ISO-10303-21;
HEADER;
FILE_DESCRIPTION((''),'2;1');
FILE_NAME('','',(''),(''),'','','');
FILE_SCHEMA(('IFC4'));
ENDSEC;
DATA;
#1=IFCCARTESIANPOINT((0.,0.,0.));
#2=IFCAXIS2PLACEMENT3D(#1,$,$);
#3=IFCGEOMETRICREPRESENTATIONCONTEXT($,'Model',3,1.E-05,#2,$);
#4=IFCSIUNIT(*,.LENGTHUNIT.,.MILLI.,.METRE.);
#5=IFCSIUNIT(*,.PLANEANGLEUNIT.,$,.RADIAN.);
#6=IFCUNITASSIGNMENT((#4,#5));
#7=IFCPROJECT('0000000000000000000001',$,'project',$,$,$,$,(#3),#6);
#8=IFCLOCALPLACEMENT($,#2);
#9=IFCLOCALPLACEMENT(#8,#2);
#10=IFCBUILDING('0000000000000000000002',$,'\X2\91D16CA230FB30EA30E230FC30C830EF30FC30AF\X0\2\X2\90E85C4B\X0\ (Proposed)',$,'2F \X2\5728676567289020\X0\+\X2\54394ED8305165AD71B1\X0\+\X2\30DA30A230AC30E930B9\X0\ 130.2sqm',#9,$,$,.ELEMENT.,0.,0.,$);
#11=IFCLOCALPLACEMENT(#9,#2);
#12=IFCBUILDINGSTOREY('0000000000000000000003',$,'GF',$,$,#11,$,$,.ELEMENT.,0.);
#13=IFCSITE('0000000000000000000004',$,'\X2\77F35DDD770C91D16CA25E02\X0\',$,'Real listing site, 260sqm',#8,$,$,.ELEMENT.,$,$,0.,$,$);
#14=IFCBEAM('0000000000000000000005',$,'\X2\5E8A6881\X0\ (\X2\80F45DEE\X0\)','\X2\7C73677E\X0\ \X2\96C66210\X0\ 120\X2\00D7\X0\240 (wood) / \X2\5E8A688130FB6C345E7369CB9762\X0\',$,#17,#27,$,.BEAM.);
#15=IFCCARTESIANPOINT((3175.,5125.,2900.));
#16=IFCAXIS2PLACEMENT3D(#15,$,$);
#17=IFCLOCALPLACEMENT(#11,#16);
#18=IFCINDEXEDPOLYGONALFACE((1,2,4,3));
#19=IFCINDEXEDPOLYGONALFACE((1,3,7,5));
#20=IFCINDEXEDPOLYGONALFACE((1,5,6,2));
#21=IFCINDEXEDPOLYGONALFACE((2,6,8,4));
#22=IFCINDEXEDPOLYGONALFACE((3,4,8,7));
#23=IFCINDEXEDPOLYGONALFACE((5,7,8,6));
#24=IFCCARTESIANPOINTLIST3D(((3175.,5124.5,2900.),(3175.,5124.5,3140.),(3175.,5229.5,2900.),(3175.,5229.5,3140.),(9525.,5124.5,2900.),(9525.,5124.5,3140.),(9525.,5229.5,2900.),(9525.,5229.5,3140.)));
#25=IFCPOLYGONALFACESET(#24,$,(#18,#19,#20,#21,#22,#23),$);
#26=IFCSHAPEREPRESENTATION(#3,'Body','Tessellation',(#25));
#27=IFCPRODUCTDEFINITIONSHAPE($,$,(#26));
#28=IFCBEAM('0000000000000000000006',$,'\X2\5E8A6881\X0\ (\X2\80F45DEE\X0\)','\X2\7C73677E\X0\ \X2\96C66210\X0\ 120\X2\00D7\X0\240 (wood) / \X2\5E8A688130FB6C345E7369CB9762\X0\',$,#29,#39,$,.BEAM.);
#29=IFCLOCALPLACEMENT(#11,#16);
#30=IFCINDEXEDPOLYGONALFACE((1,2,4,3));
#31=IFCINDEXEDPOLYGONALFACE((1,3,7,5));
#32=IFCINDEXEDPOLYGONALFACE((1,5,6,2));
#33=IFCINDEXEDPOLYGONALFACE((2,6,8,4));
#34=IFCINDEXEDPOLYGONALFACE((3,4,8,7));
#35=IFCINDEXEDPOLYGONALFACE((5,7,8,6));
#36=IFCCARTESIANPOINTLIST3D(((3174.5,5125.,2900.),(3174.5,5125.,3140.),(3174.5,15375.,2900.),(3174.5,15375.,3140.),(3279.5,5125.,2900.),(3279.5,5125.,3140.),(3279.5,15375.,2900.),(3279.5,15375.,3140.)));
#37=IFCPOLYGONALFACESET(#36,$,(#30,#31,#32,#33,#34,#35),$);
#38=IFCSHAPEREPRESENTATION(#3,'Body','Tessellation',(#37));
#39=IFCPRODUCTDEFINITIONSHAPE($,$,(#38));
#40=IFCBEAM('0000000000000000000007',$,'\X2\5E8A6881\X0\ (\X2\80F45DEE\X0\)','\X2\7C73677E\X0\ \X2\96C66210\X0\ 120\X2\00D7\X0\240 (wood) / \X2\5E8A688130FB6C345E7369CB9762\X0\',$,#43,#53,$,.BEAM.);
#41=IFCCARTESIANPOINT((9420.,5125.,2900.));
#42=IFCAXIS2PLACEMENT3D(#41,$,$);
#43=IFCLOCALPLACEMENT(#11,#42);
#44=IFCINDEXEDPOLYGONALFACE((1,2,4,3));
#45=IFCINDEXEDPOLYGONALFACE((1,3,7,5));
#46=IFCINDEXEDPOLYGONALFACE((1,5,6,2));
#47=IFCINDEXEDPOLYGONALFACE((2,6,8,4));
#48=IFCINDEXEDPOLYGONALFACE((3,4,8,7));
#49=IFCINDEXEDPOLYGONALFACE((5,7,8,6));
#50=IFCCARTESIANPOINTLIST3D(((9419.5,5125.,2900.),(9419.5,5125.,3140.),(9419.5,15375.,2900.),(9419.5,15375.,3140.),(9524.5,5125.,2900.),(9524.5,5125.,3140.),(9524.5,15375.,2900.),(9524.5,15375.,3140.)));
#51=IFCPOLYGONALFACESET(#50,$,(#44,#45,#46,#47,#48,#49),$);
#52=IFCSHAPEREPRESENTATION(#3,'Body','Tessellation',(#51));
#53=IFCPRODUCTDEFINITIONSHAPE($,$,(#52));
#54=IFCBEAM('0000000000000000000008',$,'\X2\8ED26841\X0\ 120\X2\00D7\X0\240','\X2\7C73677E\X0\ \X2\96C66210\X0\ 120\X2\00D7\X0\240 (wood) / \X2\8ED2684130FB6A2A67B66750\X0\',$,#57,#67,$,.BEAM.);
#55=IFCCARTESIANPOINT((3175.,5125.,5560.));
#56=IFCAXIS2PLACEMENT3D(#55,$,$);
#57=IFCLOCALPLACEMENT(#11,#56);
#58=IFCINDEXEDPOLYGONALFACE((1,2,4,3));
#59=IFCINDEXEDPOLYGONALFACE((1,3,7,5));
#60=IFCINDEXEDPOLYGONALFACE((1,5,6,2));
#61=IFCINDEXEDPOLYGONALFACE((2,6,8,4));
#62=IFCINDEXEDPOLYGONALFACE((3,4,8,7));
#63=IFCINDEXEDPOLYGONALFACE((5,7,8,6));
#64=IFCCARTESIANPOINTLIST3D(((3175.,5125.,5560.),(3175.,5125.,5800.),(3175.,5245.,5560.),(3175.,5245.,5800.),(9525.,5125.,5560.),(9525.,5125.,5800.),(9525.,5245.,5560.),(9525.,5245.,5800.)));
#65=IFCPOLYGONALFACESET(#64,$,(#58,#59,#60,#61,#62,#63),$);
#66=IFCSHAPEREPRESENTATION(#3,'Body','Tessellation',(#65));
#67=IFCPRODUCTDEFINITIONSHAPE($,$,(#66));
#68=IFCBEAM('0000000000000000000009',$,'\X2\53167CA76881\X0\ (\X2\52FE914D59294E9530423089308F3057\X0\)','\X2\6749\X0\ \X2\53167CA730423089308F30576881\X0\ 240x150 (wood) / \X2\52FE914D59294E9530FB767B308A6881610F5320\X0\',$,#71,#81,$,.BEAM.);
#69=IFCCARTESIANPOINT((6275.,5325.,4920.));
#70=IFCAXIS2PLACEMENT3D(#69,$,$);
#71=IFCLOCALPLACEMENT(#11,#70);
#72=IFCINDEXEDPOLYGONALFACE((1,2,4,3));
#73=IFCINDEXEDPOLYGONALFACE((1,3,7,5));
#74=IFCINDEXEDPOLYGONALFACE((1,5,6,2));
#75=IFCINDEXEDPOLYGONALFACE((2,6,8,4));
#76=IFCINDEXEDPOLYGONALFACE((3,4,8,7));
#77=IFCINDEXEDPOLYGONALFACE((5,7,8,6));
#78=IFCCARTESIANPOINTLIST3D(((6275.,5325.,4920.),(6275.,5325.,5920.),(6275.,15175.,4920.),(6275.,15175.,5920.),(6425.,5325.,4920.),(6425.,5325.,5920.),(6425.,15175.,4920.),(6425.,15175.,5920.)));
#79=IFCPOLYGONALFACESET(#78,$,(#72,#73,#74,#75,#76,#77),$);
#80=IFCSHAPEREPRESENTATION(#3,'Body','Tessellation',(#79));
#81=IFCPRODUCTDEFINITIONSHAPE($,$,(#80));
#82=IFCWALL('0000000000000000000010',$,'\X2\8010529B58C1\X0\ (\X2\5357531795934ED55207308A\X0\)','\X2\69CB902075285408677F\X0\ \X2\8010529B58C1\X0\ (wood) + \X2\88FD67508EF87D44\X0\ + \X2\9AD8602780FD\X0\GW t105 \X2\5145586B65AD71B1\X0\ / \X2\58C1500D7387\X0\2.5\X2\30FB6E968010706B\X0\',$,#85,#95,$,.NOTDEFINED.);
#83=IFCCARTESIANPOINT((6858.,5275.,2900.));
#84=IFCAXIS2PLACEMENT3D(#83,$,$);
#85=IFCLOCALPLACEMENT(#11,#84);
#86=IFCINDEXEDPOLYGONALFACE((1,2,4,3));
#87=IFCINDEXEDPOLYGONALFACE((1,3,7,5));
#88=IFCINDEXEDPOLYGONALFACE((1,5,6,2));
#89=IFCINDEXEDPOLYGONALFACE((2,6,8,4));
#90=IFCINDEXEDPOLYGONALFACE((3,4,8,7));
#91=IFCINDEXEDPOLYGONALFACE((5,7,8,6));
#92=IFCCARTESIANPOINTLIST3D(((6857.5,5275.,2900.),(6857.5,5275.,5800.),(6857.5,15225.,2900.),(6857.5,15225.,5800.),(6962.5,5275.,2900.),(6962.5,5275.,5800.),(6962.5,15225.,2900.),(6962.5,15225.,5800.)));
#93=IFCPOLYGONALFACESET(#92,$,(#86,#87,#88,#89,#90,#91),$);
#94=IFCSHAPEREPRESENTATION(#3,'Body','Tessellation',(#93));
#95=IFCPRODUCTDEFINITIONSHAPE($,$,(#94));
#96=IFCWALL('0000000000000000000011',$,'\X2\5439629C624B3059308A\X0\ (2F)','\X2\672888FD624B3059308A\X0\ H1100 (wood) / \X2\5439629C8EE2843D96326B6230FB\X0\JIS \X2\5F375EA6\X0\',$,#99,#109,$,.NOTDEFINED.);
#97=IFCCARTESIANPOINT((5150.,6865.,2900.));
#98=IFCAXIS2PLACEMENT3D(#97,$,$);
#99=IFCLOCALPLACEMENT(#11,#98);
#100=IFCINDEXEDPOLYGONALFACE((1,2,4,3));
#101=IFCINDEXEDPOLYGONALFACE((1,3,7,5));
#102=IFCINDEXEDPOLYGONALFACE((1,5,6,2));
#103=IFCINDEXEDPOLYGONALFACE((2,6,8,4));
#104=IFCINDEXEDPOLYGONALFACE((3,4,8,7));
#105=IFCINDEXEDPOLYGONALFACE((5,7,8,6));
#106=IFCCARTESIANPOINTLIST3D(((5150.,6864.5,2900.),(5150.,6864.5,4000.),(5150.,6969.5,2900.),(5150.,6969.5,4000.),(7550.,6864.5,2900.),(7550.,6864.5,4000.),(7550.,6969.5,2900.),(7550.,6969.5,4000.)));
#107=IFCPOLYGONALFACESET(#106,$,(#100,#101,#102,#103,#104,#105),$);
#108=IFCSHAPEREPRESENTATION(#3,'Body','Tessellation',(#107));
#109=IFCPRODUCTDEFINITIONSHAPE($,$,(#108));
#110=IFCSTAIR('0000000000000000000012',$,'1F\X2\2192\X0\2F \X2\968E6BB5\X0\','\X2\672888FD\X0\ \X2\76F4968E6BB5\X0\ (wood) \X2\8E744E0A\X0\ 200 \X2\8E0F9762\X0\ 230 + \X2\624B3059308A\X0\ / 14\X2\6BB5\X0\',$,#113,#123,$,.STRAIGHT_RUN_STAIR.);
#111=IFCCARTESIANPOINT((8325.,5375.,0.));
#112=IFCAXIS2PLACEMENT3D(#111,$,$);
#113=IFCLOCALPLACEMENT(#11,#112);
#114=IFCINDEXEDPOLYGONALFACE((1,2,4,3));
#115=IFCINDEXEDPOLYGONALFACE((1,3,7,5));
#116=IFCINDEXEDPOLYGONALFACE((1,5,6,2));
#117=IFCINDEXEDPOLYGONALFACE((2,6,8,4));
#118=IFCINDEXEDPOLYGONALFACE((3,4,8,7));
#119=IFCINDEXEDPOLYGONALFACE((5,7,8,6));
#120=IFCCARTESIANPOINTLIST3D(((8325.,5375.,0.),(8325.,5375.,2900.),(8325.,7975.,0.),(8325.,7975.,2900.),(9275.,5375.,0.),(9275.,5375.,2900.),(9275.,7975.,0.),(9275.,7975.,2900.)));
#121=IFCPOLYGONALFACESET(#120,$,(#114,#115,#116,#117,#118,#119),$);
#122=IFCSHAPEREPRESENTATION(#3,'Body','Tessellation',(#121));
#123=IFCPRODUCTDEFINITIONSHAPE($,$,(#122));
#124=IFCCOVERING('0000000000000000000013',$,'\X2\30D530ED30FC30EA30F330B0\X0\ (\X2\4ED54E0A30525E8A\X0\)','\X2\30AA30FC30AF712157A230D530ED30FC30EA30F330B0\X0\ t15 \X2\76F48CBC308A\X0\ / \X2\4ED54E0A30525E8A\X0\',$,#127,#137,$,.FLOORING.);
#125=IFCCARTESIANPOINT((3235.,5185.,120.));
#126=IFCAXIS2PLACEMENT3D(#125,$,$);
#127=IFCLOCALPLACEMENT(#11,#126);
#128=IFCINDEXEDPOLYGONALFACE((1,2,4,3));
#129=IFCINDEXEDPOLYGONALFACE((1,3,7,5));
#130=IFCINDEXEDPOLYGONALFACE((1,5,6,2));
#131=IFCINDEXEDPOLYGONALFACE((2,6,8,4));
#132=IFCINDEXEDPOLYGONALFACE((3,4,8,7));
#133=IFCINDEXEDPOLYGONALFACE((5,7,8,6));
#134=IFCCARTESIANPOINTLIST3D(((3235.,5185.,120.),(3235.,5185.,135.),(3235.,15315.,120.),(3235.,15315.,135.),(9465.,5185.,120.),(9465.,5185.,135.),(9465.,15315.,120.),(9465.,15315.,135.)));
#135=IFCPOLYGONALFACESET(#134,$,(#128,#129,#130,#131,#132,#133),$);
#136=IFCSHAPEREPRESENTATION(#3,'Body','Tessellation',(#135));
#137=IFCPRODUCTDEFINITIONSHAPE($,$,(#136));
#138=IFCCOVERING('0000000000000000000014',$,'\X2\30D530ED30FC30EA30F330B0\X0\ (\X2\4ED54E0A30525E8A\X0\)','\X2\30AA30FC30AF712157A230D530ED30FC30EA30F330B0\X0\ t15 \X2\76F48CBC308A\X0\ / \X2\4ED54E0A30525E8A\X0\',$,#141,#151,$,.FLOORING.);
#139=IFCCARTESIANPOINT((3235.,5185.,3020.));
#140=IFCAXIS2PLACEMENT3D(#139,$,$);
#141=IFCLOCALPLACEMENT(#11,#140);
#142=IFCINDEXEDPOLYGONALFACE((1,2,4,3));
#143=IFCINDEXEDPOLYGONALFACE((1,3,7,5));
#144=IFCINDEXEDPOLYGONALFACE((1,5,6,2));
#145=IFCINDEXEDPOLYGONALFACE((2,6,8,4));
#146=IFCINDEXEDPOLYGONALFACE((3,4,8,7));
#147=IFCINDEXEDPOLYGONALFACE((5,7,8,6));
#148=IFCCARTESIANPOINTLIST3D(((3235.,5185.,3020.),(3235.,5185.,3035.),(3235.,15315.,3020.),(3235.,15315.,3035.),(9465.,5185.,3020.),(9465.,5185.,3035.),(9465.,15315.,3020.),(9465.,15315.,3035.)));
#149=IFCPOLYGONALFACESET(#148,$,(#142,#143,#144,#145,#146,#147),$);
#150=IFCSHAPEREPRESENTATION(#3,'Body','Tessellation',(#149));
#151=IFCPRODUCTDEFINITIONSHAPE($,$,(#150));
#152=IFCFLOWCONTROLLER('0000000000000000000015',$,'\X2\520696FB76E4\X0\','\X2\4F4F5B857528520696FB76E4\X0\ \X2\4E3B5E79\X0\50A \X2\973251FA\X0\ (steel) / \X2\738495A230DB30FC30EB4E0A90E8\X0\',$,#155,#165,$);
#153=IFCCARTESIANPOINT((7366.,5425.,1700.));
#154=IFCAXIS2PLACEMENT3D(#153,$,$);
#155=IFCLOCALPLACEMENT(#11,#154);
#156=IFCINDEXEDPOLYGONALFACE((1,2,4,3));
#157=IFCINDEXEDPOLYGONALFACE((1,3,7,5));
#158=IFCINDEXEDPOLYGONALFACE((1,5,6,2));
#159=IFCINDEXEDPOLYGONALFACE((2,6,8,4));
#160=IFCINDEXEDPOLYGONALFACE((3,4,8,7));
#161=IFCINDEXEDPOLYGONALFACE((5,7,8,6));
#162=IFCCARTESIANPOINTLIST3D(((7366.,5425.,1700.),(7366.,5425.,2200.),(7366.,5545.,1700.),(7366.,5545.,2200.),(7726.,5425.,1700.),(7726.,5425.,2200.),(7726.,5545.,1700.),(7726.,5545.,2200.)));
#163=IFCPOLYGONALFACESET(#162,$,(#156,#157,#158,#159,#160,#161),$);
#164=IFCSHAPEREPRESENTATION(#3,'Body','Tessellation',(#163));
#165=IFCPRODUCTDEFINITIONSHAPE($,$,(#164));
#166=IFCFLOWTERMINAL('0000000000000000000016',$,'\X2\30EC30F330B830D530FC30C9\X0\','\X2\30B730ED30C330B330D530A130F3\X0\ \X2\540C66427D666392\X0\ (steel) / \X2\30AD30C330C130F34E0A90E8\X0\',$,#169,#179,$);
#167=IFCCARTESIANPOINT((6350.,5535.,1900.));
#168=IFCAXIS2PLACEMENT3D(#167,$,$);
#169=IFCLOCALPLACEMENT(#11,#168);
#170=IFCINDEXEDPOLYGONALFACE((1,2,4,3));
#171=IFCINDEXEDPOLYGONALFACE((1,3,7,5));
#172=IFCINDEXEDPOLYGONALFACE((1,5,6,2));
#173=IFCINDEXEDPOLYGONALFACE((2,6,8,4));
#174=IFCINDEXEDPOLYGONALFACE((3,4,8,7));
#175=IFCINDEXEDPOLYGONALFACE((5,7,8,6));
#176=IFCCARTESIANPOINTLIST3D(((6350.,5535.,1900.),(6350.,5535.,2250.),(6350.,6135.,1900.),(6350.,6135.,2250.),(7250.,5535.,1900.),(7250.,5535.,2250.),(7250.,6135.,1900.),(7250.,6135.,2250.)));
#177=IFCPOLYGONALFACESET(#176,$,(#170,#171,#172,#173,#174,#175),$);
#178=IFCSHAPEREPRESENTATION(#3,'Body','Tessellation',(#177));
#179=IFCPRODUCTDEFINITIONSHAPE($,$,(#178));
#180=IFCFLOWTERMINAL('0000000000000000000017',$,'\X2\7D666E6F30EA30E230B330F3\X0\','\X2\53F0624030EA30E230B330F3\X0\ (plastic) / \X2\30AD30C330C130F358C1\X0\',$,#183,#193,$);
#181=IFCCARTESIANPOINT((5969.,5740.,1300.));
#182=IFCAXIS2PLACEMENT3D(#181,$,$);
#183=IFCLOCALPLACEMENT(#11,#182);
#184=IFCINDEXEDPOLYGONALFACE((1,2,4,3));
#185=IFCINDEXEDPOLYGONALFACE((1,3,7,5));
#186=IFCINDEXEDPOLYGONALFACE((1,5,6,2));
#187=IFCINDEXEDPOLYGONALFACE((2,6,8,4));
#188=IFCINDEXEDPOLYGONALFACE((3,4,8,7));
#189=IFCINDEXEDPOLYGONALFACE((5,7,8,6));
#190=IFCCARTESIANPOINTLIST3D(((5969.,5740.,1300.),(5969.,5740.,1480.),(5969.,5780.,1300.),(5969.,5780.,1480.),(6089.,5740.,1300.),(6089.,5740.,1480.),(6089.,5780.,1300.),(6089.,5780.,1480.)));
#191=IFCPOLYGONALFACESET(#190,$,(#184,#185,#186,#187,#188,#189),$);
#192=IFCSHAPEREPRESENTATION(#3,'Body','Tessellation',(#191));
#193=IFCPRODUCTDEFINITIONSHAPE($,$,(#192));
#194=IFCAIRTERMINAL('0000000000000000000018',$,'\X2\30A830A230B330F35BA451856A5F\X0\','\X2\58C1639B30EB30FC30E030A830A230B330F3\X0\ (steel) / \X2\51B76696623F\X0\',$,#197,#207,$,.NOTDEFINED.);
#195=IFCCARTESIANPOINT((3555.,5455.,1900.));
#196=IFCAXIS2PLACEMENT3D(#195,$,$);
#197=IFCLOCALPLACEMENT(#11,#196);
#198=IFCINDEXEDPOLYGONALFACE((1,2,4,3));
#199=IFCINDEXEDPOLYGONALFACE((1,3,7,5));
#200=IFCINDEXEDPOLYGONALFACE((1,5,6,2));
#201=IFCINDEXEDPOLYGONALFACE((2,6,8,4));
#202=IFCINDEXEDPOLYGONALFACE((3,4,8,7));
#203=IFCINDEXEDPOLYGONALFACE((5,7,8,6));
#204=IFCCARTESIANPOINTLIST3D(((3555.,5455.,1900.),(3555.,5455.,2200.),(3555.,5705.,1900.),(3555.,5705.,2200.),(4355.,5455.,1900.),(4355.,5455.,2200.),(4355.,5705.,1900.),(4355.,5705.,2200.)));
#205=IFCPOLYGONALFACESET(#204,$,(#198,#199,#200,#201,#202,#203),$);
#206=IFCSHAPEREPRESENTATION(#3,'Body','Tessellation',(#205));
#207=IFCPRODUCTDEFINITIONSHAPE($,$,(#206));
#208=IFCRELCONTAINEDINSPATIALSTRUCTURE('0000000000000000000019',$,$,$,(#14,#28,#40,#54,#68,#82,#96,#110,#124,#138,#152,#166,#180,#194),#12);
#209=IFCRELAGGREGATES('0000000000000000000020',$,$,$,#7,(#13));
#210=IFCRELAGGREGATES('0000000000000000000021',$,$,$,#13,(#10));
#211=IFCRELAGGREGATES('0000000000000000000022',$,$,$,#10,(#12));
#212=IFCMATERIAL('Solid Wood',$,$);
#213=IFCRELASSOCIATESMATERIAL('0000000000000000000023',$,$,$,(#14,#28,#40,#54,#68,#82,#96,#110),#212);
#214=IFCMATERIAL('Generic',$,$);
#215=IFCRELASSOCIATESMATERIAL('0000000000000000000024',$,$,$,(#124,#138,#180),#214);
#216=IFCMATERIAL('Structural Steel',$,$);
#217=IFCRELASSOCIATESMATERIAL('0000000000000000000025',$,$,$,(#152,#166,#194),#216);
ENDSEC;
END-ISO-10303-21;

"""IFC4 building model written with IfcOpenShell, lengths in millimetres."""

from ifc_helpers import new_model, si_unit, frame, frame_2d, origin, place, context, project, spatial, rectangle, extrude, material, element, save


model = new_model("IFC4")

# Units and contexts
model_context = context("Model", 3, precision=1e-05, world=origin())
ifc_project = project(units=[si_unit("LENGTHUNIT", "METRE", prefix="MILLI"), si_unit("PLANEANGLEUNIT", "RADIAN")], contexts=[model_context])

# Site, building, storey
site_placement = place(None, origin())
site = spatial("IfcSite", under=ifc_project, at=site_placement, Name="石川県金沢市", ObjectType="Real listing site, 260sqm", CompositionType="ELEMENT", RefElevation=0.0)
building_placement = place(site_placement, origin())
building = spatial("IfcBuilding", under=site, at=building_placement, Name="金沢・リモートワーク2部屋 (Proposed)", ObjectType="2F 在来木造+吹付け断熱+ペアガラス 130.2sqm", CompositionType="ELEMENT", ElevationOfRefHeight=0.0, ElevationOfTerrain=0.0)
storey_placement = place(building_placement, origin())
storey = spatial("IfcBuildingStorey", under=building, at=storey_placement, Name="GF", CompositionType="ELEMENT", Elevation=0.0)

# Shared definitions
ifc_material_1 = material(Name="Solid Wood")

# Beams
beam_1_placement = place(storey_placement, frame((3175.0, 5125.0, 2900.0)))
element("IfcBeam", 1, at=beam_1_placement, inside=storey, material=ifc_material_1, Name="床梁 (胴差)", Description="米松 集成 120×240 (wood) / 床梁・水平構面", PredefinedType="BEAM", context=model_context, shape_type="SweptSolid", body=[
    extrude(rectangle(XDim=6350.0, YDim=105.0, at=frame_2d((3175.0, 52.0))), frame((3175.0, 5125.0, 2900.0)), (0.0, 0.0, 1.0), 240.0),
])
beam_2_placement = place(storey_placement, frame((3175.0, 5125.0, 2900.0)))
element("IfcBeam", 2, at=beam_2_placement, inside=storey, material=ifc_material_1, Name="床梁 (胴差)", Description="米松 集成 120×240 (wood) / 床梁・水平構面", PredefinedType="BEAM", context=model_context, shape_type="SweptSolid", body=[
    extrude(rectangle(XDim=105.0, YDim=10250.0, at=frame_2d((52.0, 5125.0))), frame((3175.0, 5125.0, 2900.0)), (0.0, 0.0, 1.0), 240.0),
])
beam_3_placement = place(storey_placement, frame((9420.0, 5125.0, 2900.0)))
element("IfcBeam", 3, at=beam_3_placement, inside=storey, material=ifc_material_1, Name="床梁 (胴差)", Description="米松 集成 120×240 (wood) / 床梁・水平構面", PredefinedType="BEAM", context=model_context, shape_type="SweptSolid", body=[
    extrude(rectangle(XDim=105.0, YDim=10250.0, at=frame_2d((52.0, 5125.0))), frame((9420.0, 5125.0, 2900.0)), (0.0, 0.0, 1.0), 240.0),
])
beam_4_placement = place(storey_placement, frame((3175.0, 5125.0, 5560.0)))
element("IfcBeam", 4, at=beam_4_placement, inside=storey, material=ifc_material_1, Name="軒桁 120×240", Description="米松 集成 120×240 (wood) / 軒桁・横架材", PredefinedType="BEAM", context=model_context, shape_type="SweptSolid", body=[
    extrude(rectangle(XDim=6350.0, YDim=120.0, at=frame_2d((3175.0, 60.0))), frame((3175.0, 5125.0, 5560.0)), (0.0, 0.0, 1.0), 240.0),
])
beam_5_placement = place(storey_placement, frame((6275.0, 5325.0, 4920.0)))
element("IfcBeam", 5, at=beam_5_placement, inside=storey, material=ifc_material_1, Name="化粧梁 (勾配天井あらわし)", Description="杉 化粧あらわし梁 240x150 (wood) / 勾配天井・登り梁意匠", PredefinedType="BEAM", context=model_context, shape_type="SweptSolid", body=[
    extrude(rectangle(XDim=150.0, YDim=9850.0, at=frame_2d((75.0, 4925.0))), frame((6275.0, 5325.0, 4920.0)), (0.0, 0.0, 1.0), 1000.0),
])

# Walls
wall_1_placement = place(storey_placement, frame((6858.0, 5275.0, 2900.0)))
element("IfcWall", 6, at=wall_1_placement, inside=storey, material=ifc_material_1, Name="耐力壁 (南北間仕切り)", Description="構造用合板 耐力壁 (wood) + 製材軸組 + 高性能GW t105 充填断熱 / 壁倍率2.5・準耐火", PredefinedType="NOTDEFINED", context=model_context, shape_type="SweptSolid", body=[
    extrude(rectangle(XDim=105.0, YDim=9950.0, at=frame_2d((52.0, 4975.0))), frame((6858.0, 5275.0, 2900.0)), (0.0, 0.0, 1.0), 2900.0),
])
wall_2_placement = place(storey_placement, frame((5150.0, 6865.0, 2900.0)))
element("IfcWall", 7, at=wall_2_placement, inside=storey, material=ifc_material_1, Name="吹抜手すり (2F)", Description="木製手すり H1100 (wood) / 吹抜転落防止・JIS 強度", PredefinedType="NOTDEFINED", context=model_context, shape_type="SweptSolid", body=[
    extrude(rectangle(XDim=2400.0, YDim=105.0, at=frame_2d((1200.0, 52.0))), frame((5150.0, 6865.0, 2900.0)), (0.0, 0.0, 1.0), 1100.0),
])

# Stair
stair_placement = place(storey_placement, frame((8325.0, 5375.0, 0.0)))
element("IfcStair", 8, at=stair_placement, inside=storey, material=ifc_material_1, Name="1F→2F 階段", Description="木製 直階段 (wood) 蹴上 200 踏面 230 + 手すり / 14段", PredefinedType="STRAIGHT_RUN_STAIR", context=model_context, shape_type="SweptSolid", body=[
    extrude(rectangle(XDim=950.0, YDim=2600.0, at=frame_2d((475.0, 1300.0))), frame((8325.0, 5375.0, 0.0)), (0.0, 0.0, 1.0), 2900.0),
])

# Coverings
ifc_material_2 = material(Name="Generic")
covering_1_placement = place(storey_placement, frame((3235.0, 5185.0, 120.0)))
element("IfcCovering", 9, at=covering_1_placement, inside=storey, material=ifc_material_2, Name="フローリング (仕上げ床)", Description="オーク無垢フローリング t15 直貼り / 仕上げ床", PredefinedType="FLOORING", context=model_context, shape_type="SweptSolid", body=[
    extrude(rectangle(XDim=6230.0, YDim=10130.0, at=frame_2d((3115.0, 5065.0))), frame((3235.0, 5185.0, 120.0)), (0.0, 0.0, 1.0), 15.0),
])
covering_2_placement = place(storey_placement, frame((3235.0, 5185.0, 3020.0)))
element("IfcCovering", 10, at=covering_2_placement, inside=storey, material=ifc_material_2, Name="フローリング (仕上げ床)", Description="オーク無垢フローリング t15 直貼り / 仕上げ床", PredefinedType="FLOORING", context=model_context, shape_type="SweptSolid", body=[
    extrude(rectangle(XDim=6230.0, YDim=10130.0, at=frame_2d((3115.0, 5065.0))), frame((3235.0, 5185.0, 3020.0)), (0.0, 0.0, 1.0), 15.0),
])

# Flow controller
ifc_material_3 = material(Name="Structural Steel")
flow_controller_placement = place(storey_placement, frame((7366.0, 5425.0, 1700.0)))
element("IfcFlowController", 11, at=flow_controller_placement, inside=storey, material=ifc_material_3, Name="分電盤", Description="住宅用分電盤 主幹50A 露出 (steel) / 玄関ホール上部", context=model_context, shape_type="SweptSolid", body=[
    extrude(rectangle(XDim=360.0, YDim=120.0, at=frame_2d((180.0, 60.0))), frame((7366.0, 5425.0, 1700.0)), (0.0, 0.0, 1.0), 500.0),
])

# Flow terminals
flow_terminal_1_placement = place(storey_placement, frame((6350.0, 5535.0, 1900.0)))
element("IfcFlowTerminal", 12, at=flow_terminal_1_placement, inside=storey, material=ifc_material_3, Name="レンジフード", Description="シロッコファン 同時給排 (steel) / キッチン上部", context=model_context, shape_type="SweptSolid", body=[
    extrude(rectangle(XDim=900.0, YDim=600.0, at=frame_2d((450.0, 300.0))), frame((6350.0, 5535.0, 1900.0)), (0.0, 0.0, 1.0), 350.0),
])
flow_terminal_2_placement = place(storey_placement, frame((5969.0, 5740.0, 1300.0)))
element("IfcFlowTerminal", 13, at=flow_terminal_2_placement, inside=storey, material=ifc_material_2, Name="給湯リモコン", Description="台所リモコン (plastic) / キッチン壁", context=model_context, shape_type="SweptSolid", body=[
    extrude(rectangle(XDim=120.0, YDim=40.0, at=frame_2d((60.0, 20.0))), frame((5969.0, 5740.0, 1300.0)), (0.0, 0.0, 1.0), 180.0),
])

# Air terminal
air_terminal_1_placement = place(storey_placement, frame((3555.0, 5455.0, 1900.0)))
element("IfcAirTerminal", 14, at=air_terminal_1_placement, inside=storey, material=ifc_material_3, Name="エアコン室内機", Description="壁掛ルームエアコン (steel) / 冷暖房", PredefinedType="NOTDEFINED", context=model_context, shape_type="SweptSolid", body=[
    extrude(rectangle(XDim=800.0, YDim=250.0, at=frame_2d((400.0, 125.0))), frame((3555.0, 5455.0, 1900.0)), (0.0, 0.0, 1.0), 300.0),
])

save(model, "model.ifc")
